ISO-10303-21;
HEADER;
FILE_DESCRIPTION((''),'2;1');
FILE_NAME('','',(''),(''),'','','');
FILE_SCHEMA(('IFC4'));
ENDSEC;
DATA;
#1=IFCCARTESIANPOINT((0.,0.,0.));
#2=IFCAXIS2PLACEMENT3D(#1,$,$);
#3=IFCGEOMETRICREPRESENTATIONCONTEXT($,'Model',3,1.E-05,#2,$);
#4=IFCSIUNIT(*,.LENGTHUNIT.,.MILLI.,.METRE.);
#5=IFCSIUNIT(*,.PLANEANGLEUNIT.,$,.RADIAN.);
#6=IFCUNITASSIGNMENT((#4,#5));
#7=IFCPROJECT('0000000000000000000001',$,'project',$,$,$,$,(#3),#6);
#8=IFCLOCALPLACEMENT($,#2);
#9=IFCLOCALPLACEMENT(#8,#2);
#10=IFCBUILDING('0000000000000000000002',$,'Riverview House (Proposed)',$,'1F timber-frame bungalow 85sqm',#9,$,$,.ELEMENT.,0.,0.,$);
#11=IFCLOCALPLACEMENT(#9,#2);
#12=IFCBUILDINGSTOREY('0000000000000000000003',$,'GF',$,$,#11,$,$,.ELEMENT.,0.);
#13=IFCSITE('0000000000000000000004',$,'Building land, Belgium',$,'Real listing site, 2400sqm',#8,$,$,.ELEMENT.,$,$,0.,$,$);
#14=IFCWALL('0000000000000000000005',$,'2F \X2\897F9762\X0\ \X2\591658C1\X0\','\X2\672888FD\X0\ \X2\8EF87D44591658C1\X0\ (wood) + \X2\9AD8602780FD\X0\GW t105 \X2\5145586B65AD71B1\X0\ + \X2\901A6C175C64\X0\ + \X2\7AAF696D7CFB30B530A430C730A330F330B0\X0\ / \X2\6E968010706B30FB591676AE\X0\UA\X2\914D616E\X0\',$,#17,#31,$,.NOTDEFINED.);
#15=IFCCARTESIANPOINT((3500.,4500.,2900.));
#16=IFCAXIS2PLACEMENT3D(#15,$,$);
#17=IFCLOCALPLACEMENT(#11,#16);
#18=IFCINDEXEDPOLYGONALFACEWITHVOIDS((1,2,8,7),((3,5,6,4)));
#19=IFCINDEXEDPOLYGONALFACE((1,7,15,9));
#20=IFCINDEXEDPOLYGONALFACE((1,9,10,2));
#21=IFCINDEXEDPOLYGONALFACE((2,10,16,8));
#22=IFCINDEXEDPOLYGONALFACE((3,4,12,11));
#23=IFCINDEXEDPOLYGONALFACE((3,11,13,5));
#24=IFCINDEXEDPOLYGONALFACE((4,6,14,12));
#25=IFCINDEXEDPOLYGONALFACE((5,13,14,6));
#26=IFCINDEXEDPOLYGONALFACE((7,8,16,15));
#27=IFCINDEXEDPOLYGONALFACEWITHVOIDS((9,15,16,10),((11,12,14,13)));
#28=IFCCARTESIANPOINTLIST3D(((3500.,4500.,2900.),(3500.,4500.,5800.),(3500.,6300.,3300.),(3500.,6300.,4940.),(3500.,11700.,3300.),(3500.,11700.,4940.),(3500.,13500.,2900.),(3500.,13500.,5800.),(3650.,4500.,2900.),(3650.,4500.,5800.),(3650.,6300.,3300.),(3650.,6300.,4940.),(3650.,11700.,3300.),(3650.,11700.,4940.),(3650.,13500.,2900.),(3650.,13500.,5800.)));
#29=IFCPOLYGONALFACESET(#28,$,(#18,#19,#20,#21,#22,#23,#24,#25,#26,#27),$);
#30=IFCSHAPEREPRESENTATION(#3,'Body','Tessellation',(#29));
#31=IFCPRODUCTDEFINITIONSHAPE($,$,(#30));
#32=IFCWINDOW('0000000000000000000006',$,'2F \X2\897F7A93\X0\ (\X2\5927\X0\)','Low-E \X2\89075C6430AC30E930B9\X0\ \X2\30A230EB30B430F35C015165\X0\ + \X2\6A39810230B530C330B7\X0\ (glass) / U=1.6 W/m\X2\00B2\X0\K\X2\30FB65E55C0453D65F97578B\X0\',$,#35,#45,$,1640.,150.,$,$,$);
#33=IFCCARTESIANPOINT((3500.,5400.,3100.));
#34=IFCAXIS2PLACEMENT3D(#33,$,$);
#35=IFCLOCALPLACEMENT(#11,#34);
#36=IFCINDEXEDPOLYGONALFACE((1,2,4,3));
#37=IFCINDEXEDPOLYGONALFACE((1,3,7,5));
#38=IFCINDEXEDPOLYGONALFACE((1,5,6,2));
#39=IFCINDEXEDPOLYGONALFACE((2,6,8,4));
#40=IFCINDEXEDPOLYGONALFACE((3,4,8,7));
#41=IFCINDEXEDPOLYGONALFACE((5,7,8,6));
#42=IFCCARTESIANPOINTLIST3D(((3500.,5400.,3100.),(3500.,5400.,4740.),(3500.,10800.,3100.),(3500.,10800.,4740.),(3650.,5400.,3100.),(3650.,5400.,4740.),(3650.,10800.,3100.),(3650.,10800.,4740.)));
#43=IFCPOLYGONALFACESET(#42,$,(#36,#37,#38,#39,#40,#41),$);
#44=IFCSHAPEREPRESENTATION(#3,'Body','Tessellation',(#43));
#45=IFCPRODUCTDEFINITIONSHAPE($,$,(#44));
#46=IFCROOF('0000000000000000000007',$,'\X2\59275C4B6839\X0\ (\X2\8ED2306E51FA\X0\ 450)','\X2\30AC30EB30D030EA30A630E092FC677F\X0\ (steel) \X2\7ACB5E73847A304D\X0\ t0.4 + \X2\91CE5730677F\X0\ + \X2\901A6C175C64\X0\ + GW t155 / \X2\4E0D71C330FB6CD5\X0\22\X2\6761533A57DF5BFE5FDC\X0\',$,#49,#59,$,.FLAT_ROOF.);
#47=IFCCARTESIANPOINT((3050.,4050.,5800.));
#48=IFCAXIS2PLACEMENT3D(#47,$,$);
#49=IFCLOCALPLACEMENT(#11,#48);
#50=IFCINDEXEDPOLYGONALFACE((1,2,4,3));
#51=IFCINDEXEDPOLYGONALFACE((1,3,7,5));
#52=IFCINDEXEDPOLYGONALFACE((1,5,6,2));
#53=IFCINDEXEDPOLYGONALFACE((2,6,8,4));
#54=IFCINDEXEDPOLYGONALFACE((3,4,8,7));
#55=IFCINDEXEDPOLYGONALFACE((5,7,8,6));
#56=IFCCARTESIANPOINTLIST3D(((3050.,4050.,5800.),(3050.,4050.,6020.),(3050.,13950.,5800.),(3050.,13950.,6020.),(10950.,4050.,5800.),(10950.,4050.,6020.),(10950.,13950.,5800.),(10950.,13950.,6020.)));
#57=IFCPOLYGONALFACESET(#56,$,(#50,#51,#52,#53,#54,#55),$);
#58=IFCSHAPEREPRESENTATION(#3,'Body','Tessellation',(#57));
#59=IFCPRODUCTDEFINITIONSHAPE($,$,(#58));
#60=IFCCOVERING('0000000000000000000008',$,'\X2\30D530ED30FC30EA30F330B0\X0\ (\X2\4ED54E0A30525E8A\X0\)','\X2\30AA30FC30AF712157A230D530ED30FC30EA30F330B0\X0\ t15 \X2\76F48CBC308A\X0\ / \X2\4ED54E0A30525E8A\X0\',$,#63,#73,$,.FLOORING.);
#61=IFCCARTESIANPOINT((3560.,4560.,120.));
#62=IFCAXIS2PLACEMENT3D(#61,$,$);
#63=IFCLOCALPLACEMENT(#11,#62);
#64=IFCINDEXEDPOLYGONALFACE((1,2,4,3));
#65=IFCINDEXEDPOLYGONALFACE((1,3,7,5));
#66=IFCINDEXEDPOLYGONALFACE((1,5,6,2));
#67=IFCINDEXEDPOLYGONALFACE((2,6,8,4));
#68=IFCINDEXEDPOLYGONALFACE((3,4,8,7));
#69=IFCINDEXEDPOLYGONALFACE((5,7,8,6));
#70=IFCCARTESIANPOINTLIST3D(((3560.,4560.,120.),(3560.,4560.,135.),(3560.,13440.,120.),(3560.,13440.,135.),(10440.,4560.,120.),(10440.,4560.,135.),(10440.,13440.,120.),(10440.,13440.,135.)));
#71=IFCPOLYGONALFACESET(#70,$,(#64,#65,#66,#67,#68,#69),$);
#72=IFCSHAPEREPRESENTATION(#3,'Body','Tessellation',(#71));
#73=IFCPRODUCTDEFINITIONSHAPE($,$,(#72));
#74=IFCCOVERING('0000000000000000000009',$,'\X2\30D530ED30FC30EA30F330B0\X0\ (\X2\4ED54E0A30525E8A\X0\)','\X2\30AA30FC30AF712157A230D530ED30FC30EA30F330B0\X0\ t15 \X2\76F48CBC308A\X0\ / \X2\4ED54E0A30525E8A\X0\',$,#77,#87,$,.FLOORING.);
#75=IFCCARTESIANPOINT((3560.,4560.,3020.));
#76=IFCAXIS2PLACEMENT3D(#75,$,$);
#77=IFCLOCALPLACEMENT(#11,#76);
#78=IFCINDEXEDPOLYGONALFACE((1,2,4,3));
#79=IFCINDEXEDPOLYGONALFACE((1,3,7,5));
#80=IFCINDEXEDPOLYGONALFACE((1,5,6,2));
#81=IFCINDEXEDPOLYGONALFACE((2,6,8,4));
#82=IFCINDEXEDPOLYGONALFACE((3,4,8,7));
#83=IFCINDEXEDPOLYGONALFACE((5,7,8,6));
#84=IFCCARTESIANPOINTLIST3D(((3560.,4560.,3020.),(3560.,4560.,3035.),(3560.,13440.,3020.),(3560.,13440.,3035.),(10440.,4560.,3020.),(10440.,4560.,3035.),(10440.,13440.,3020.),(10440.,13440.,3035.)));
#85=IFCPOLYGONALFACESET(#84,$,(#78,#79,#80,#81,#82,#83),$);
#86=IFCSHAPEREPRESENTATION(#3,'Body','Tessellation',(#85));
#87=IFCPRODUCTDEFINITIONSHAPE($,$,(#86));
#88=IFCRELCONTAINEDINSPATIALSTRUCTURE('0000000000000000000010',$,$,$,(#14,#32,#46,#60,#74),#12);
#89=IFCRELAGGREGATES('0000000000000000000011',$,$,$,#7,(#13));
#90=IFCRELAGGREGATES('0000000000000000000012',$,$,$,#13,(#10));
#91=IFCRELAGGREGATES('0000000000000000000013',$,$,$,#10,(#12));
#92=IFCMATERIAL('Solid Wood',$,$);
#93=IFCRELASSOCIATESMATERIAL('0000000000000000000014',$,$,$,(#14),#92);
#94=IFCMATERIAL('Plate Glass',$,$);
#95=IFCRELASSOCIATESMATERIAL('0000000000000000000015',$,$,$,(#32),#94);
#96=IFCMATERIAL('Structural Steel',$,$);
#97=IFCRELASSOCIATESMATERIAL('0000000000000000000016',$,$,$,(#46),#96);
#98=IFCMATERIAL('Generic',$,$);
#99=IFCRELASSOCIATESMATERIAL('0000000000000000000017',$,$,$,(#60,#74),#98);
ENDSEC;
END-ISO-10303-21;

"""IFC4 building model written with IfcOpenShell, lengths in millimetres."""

from ifc_helpers import new_model, si_unit, frame, frame_2d, origin, place, context, project, spatial, rectangle, extrude, material, element, fill, save


model = new_model("IFC4")

# Units and contexts
model_context = context("Model", 3, precision=1e-05, world=origin())
ifc_project = project(units=[si_unit("LENGTHUNIT", "METRE", prefix="MILLI"), si_unit("PLANEANGLEUNIT", "RADIAN")], contexts=[model_context])

# Site, building, storey
site_placement = place(None, origin())
site = spatial("IfcSite", under=ifc_project, at=site_placement, Name="Building land, Belgium", ObjectType="Real listing site, 2400sqm", CompositionType="ELEMENT", RefElevation=0.0)
building_placement = place(site_placement, origin())
building = spatial("IfcBuilding", under=site, at=building_placement, Name="Riverview House (Proposed)", ObjectType="1F timber-frame bungalow 85sqm", CompositionType="ELEMENT", ElevationOfRefHeight=0.0, ElevationOfTerrain=0.0)
storey_placement = place(building_placement, origin())
storey = spatial("IfcBuildingStorey", under=building, at=storey_placement, Name="GF", CompositionType="ELEMENT", Elevation=0.0)

# Shared definitions
ifc_material_1 = material(Name="Solid Wood")
ifc_material_2 = material(Name="Generic")

# Shared definitions
ifc_material_3 = material(Name="Plate Glass")

# Wall, opening, window
wall_1_placement = place(storey_placement, frame((3500.0, 4500.0, 2900.0)))
wall_1 = element("IfcWall", 1, at=wall_1_placement, inside=storey, material=ifc_material_1, Name="2F 西面 外壁", Description="木製 軸組外壁 (wood) + 高性能GW t105 充填断熱 + 通気層 + 窯業系サイディング / 準耐火・外皮UA配慮", PredefinedType="NOTDEFINED", context=model_context, shape_type="SweptSolid", body=[
    extrude(rectangle(XDim=150.0, YDim=9000.0, at=frame_2d((75.0, 4500.0))), frame((3500.0, 4500.0, 2900.0)), (0.0, 0.0, 1.0), 2900.0),
])
opening_1_placement = place(storey_placement, frame((3500.0, 5400.0, 3100.0)))
opening_1 = element("IfcOpeningElement", 2, at=opening_1_placement, cuts=wall_1, PredefinedType="NOTDEFINED", context=model_context, shape_type="SweptSolid", body=[
    extrude(rectangle(XDim=150.0, YDim=5400.0, at=frame_2d((75.0, 2700.0))), frame((3500.0, 5400.0, 3100.0)), (0.0, 0.0, 1.0), 1640.0),
])
window_1_placement = place(storey_placement, frame((3500.0, 5400.0, 3100.0)))
window_1 = element("IfcWindow", 3, at=window_1_placement, inside=storey, material=ifc_material_3, Name="2F 西窓 (大)", Description="Low-E 複層ガラス アルゴン封入 + 樹脂サッシ (glass) / U=1.6 W/m²K・日射取得型", OverallHeight=1640.0, OverallWidth=150.0, context=model_context, shape_type="SweptSolid", body=[
    extrude(rectangle(XDim=150.0, YDim=5400.0, at=frame_2d((75.0, 2700.0))), frame((3500.0, 5400.0, 3100.0)), (0.0, 0.0, 1.0), 1640.0),
])
fill(opening_1, window_1)

# Roof
ifc_material_4 = material(Name="Structural Steel")
roof_placement = place(storey_placement, frame((3050.0, 4050.0, 5800.0)))
element("IfcRoof", 4, at=roof_placement, inside=storey, material=ifc_material_4, Name="大屋根 (軒の出 450)", Description="ガルバリウム鋼板 (steel) 立平葺き t0.4 + 野地板 + 通気層 + GW t155 / 不燃・法22条区域対応", PredefinedType="FLAT_ROOF", context=model_context, shape_type="SweptSolid", body=[
    extrude(rectangle(XDim=7900.0, YDim=9900.0, at=frame_2d((3950.0, 4950.0))), frame((3050.0, 4050.0, 5800.0)), (0.0, 0.0, 1.0), 220.0),
])

# Coverings
covering_1_placement = place(storey_placement, frame((3560.0, 4560.0, 120.0)))
element("IfcCovering", 5, at=covering_1_placement, inside=storey, material=ifc_material_2, Name="フローリング (仕上げ床)", Description="オーク無垢フローリング t15 直貼り / 仕上げ床", PredefinedType="FLOORING", context=model_context, shape_type="SweptSolid", body=[
    extrude(rectangle(XDim=6880.0, YDim=8880.0, at=frame_2d((3440.0, 4440.0))), frame((3560.0, 4560.0, 120.0)), (0.0, 0.0, 1.0), 15.0),
])
covering_2_placement = place(storey_placement, frame((3560.0, 4560.0, 3020.0)))
element("IfcCovering", 6, at=covering_2_placement, inside=storey, material=ifc_material_2, Name="フローリング (仕上げ床)", Description="オーク無垢フローリング t15 直貼り / 仕上げ床", PredefinedType="FLOORING", context=model_context, shape_type="SweptSolid", body=[
    extrude(rectangle(XDim=6880.0, YDim=8880.0, at=frame_2d((3440.0, 4440.0))), frame((3560.0, 4560.0, 3020.0)), (0.0, 0.0, 1.0), 15.0),
])

save(model, "model.ifc")
